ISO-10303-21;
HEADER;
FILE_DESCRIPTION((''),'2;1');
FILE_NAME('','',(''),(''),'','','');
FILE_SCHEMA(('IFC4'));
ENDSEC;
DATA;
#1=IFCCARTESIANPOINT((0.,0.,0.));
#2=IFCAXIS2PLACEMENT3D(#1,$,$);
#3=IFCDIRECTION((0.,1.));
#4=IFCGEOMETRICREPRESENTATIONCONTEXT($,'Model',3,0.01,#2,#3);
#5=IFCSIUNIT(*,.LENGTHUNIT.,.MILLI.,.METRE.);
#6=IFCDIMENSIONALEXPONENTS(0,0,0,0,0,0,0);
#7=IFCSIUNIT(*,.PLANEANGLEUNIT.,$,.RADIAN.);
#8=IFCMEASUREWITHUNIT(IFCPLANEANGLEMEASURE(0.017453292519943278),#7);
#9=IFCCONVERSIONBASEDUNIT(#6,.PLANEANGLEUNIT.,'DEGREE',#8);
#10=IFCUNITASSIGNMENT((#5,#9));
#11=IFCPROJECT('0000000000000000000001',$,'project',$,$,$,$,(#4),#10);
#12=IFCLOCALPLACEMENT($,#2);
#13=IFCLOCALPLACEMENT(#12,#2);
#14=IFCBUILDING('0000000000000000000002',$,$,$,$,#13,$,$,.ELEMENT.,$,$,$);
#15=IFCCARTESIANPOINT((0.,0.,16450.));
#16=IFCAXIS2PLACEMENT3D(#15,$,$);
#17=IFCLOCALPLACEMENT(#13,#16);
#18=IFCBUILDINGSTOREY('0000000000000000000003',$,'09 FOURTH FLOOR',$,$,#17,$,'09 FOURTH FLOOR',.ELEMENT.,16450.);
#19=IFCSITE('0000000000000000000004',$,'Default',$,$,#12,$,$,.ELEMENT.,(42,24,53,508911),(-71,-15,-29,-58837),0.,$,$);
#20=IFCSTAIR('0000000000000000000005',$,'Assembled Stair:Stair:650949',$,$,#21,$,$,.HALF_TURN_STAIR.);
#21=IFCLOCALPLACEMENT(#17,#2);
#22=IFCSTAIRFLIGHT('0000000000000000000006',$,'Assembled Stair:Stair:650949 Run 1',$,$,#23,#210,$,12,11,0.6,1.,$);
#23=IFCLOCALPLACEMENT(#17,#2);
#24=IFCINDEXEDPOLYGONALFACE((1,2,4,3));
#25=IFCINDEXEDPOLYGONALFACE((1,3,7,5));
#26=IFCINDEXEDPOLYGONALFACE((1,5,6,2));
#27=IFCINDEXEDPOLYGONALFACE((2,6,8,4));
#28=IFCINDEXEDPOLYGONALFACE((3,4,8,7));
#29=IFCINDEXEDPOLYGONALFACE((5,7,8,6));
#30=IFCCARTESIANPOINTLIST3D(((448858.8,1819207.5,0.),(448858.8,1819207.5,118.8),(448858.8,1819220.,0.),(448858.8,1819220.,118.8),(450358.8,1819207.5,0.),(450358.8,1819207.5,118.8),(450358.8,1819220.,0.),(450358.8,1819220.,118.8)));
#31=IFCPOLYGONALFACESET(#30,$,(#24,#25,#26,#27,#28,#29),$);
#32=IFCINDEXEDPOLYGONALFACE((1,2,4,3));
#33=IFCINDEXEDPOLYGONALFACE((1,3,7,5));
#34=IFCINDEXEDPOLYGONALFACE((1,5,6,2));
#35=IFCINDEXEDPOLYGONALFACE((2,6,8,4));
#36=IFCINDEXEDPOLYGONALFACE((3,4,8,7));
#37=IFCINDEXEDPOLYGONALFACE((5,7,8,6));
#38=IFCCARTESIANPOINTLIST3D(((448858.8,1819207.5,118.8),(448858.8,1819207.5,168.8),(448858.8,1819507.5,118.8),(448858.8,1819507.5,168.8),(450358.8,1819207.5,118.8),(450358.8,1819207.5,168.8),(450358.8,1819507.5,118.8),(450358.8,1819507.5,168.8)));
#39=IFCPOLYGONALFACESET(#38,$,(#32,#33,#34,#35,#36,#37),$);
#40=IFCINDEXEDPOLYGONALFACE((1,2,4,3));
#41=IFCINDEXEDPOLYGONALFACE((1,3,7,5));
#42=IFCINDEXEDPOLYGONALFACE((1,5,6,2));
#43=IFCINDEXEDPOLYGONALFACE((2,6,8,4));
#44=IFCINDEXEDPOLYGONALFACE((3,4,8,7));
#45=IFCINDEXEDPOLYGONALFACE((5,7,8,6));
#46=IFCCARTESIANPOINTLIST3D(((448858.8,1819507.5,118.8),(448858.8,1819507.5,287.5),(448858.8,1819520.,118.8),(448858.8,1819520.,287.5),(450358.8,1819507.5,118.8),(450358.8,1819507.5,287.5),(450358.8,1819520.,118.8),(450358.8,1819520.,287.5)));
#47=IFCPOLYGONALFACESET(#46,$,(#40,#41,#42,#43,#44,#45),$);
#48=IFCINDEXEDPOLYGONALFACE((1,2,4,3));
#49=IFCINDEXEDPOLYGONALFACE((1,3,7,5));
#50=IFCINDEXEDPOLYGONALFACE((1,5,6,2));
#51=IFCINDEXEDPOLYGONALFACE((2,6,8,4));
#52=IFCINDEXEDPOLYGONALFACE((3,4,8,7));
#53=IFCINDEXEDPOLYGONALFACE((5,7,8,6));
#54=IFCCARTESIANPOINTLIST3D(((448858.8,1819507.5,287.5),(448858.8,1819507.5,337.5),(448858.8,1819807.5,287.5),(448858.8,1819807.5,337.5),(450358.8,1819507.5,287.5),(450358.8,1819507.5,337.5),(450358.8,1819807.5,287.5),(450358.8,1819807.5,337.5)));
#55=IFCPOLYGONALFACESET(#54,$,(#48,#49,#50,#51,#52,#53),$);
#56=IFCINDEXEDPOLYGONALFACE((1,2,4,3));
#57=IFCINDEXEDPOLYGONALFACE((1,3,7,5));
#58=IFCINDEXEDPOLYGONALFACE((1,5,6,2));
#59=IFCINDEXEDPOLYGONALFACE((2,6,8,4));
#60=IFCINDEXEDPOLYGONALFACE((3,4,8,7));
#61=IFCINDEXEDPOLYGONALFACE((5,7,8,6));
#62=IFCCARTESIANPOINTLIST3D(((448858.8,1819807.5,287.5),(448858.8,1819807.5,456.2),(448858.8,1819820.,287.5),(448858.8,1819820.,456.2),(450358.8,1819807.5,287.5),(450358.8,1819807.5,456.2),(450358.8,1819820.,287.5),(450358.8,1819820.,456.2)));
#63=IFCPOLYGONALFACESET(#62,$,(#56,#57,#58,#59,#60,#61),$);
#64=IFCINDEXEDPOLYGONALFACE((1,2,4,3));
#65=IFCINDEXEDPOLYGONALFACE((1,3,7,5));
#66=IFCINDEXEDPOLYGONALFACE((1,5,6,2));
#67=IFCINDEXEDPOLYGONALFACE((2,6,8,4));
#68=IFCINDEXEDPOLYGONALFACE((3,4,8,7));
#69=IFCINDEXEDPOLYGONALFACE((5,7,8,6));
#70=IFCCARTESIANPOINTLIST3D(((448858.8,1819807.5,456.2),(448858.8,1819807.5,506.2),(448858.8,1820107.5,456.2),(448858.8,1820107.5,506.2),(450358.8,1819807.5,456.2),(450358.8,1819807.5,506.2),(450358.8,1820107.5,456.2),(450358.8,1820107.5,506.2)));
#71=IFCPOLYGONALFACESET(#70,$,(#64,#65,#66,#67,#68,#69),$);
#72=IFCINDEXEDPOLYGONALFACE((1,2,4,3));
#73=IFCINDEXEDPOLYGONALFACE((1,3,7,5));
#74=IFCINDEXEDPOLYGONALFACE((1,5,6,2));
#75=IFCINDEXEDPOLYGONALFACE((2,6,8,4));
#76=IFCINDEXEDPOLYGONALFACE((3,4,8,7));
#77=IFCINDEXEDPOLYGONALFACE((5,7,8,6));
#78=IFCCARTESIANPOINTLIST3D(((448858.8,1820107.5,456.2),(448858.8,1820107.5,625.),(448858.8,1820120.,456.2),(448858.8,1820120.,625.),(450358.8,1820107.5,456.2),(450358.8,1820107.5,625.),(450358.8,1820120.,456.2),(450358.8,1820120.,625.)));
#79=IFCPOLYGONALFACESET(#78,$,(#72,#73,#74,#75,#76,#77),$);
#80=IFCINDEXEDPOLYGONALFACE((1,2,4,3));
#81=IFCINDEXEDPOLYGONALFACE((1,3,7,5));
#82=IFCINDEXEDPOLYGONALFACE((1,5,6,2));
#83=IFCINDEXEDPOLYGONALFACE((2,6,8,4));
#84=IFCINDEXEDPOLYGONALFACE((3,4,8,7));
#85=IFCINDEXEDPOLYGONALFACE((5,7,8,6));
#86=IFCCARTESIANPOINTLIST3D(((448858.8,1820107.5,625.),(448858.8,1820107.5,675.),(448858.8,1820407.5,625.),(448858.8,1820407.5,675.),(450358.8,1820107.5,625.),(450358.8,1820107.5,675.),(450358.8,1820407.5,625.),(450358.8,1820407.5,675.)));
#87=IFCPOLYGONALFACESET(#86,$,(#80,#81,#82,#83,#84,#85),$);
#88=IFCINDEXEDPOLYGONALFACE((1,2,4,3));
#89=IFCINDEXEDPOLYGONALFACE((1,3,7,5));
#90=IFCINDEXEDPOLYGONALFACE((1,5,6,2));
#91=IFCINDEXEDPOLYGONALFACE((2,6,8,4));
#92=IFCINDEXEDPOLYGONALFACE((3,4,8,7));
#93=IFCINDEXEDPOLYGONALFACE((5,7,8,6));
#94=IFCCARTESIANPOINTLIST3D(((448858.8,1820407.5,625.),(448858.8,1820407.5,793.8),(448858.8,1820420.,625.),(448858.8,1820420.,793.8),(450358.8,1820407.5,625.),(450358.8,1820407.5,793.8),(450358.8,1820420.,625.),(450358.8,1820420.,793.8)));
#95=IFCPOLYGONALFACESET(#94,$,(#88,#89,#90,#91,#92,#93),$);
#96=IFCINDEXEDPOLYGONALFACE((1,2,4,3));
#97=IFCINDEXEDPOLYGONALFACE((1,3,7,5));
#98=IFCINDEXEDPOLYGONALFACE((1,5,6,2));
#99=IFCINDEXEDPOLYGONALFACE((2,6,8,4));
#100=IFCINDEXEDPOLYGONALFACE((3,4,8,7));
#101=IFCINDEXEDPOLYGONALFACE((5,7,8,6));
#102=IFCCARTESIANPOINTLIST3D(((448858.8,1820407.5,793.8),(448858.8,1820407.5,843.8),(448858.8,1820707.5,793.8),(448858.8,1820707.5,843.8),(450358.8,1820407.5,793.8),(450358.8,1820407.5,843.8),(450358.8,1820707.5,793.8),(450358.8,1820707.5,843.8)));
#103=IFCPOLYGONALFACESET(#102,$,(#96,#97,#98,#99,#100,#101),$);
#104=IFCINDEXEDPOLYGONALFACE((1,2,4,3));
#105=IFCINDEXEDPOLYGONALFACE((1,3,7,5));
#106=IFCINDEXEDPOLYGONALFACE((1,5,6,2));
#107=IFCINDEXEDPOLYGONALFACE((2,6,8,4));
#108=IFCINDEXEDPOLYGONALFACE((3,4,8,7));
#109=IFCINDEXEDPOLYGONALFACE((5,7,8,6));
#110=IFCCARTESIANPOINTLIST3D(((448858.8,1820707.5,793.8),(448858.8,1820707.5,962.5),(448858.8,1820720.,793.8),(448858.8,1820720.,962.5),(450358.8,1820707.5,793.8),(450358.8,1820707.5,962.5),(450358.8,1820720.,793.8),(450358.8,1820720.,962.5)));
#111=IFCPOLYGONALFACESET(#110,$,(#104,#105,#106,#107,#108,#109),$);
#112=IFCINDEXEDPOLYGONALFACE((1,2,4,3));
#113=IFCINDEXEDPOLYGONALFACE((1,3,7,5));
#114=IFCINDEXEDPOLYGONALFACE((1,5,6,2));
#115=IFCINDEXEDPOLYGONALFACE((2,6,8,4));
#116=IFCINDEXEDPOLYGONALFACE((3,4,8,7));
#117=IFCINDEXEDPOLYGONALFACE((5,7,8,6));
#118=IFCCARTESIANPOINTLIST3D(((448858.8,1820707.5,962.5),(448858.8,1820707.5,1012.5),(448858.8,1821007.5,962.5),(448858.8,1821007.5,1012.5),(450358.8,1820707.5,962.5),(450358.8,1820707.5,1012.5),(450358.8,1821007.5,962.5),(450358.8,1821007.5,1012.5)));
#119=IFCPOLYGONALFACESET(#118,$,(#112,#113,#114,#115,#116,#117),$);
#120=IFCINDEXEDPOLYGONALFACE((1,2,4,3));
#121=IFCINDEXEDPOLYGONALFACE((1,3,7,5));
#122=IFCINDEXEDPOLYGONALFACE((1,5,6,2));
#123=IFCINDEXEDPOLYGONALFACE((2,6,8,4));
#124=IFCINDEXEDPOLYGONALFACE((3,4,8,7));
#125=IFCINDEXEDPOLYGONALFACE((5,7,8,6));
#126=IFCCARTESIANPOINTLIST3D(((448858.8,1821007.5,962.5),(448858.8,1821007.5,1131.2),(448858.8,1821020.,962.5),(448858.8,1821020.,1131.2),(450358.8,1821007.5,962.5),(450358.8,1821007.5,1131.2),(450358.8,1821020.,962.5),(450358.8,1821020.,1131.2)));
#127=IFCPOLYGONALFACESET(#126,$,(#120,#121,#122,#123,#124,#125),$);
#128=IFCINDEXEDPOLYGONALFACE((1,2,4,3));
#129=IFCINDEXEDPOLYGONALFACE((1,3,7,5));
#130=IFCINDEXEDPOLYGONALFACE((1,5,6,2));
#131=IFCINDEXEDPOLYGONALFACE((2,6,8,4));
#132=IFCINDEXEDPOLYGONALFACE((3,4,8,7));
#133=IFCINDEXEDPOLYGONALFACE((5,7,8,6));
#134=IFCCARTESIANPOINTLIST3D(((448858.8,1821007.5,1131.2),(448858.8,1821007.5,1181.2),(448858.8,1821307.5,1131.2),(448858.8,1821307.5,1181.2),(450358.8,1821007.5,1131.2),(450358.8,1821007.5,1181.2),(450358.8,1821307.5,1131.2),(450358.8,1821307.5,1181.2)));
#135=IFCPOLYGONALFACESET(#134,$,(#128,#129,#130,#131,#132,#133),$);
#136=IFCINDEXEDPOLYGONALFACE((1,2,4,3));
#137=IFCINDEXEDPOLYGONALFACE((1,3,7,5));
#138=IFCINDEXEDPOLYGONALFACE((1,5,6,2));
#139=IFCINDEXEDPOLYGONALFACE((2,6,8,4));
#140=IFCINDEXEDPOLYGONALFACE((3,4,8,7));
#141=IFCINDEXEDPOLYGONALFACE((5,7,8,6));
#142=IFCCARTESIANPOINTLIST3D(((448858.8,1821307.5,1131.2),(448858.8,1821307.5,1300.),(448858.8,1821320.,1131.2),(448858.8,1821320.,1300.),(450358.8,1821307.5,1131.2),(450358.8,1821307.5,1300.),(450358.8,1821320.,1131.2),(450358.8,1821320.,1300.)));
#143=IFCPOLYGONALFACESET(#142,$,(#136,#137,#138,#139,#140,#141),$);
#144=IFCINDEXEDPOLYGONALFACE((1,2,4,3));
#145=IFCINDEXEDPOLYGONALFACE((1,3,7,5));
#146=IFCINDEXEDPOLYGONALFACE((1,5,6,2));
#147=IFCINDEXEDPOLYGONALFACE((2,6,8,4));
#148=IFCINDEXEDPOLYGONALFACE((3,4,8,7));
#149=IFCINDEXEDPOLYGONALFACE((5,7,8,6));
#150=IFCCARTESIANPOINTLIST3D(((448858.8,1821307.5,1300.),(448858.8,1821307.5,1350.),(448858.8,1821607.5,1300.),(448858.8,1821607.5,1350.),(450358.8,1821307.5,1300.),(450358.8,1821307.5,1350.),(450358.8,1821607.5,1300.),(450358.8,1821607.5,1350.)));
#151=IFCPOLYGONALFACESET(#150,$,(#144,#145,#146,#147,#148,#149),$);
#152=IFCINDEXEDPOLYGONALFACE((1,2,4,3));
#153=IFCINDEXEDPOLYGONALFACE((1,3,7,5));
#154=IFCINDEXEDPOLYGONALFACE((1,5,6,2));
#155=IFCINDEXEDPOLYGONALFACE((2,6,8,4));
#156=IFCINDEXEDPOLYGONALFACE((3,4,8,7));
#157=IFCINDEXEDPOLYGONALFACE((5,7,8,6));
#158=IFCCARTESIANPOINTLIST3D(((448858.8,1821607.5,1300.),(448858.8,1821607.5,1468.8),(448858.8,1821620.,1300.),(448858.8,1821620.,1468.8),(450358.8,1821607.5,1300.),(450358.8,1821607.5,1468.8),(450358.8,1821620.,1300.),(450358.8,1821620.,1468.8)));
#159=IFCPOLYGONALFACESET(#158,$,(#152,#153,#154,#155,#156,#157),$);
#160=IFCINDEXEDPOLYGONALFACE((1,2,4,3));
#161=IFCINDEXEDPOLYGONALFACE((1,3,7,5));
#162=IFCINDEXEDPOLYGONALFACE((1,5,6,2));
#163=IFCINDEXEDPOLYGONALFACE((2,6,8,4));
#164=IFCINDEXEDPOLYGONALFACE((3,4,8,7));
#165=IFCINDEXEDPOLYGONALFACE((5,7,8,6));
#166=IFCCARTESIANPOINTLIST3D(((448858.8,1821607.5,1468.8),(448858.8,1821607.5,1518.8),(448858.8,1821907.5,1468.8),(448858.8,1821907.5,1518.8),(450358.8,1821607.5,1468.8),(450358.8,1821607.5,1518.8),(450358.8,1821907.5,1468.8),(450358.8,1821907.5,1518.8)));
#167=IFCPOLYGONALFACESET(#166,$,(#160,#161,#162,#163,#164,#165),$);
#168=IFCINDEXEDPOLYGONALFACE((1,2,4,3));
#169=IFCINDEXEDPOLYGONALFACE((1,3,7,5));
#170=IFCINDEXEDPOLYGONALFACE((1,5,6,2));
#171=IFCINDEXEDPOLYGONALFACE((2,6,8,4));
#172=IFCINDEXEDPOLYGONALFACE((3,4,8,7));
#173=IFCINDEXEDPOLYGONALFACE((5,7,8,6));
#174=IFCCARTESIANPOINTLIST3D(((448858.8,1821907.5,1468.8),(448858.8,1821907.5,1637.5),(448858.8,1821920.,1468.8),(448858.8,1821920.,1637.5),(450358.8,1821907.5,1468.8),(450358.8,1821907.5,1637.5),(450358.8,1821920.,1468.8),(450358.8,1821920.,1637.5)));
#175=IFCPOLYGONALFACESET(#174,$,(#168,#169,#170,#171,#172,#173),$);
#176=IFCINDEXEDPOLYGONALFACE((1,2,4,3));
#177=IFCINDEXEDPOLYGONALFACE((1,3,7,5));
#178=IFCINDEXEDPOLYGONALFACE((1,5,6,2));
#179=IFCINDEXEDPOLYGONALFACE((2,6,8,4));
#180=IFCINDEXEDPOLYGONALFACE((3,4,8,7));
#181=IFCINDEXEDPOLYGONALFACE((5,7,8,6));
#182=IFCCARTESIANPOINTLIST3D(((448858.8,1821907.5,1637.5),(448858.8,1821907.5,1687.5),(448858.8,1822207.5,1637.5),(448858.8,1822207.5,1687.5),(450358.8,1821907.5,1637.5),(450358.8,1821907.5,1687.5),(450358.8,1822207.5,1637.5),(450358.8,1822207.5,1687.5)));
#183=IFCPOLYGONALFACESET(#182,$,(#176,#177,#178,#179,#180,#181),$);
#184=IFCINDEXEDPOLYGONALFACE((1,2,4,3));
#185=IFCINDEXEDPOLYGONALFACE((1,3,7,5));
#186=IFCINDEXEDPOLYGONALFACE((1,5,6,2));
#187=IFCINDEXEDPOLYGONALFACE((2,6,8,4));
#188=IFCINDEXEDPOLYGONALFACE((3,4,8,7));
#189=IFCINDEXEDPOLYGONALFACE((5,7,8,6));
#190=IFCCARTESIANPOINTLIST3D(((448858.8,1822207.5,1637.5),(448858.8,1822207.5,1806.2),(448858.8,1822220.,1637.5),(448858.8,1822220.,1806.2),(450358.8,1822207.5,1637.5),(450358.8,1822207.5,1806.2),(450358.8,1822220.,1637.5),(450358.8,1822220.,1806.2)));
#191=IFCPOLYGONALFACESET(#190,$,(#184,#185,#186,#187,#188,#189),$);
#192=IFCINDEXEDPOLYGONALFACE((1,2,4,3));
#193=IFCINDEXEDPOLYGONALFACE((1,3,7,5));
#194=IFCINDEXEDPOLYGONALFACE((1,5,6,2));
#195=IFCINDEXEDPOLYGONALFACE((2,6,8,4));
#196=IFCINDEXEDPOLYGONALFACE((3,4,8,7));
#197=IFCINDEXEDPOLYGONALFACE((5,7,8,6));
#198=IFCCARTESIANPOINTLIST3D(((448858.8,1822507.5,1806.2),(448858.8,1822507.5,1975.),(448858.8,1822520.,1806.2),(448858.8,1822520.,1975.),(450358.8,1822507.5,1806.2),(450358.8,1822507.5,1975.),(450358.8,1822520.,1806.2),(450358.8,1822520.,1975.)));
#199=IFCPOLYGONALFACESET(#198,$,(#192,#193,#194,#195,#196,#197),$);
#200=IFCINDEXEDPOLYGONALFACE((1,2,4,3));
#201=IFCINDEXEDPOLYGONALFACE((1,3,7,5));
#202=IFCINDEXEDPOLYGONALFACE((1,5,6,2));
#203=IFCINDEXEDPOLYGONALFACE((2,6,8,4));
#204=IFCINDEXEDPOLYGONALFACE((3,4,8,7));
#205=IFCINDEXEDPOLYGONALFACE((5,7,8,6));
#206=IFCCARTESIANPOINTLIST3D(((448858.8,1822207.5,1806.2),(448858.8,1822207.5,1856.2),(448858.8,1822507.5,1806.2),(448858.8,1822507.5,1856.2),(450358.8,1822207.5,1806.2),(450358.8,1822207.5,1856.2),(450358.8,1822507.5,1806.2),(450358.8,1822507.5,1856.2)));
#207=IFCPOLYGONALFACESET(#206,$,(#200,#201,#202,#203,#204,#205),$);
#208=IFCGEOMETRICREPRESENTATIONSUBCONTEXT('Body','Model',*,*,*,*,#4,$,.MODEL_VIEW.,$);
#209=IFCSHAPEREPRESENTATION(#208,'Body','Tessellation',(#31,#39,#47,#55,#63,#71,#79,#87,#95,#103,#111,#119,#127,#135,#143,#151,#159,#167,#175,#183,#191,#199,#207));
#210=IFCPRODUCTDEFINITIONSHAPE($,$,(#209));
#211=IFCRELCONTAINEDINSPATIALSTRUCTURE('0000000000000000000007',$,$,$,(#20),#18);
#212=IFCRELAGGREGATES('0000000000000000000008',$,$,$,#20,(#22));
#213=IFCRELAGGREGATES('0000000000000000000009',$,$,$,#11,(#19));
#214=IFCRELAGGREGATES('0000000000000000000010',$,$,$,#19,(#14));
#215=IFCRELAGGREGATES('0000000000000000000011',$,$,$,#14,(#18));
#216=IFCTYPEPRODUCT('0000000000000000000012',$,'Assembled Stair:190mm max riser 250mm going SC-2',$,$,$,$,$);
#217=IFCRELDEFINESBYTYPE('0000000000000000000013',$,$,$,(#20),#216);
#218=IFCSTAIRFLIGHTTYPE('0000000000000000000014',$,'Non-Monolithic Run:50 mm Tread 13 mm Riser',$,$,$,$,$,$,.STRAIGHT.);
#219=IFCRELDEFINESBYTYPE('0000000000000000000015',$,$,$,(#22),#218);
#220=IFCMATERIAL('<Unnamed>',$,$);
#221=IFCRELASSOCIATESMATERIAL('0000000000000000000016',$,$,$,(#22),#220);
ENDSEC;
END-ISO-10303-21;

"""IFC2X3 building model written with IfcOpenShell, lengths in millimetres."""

from ifc_helpers import new_model, entity, si_unit, converted_unit, direction, frame, frame_2d, origin, origin_2d_with_axis, place, context, subcontext, project, spatial, rectangle, extrude, material, type_object, element, aggregate, save


model = new_model("IFC2X3")

# Units and contexts
model_context = context("Model", 3, precision=0.01, world=origin(), true_north=direction((0.0, 1.0)))
body_context = subcontext(model_context, "Body", "Model", "MODEL_VIEW")
ifc_project = project(units=[si_unit("LENGTHUNIT", "METRE", prefix="MILLI"), converted_unit("PLANEANGLEUNIT", "DEGREE", entity("IfcPlaneAngleMeasure", 0.017453292519943278), si_unit("PLANEANGLEUNIT", "RADIAN"), dimensions=[0, 0, 0, 0, 0, 0, 0])], contexts=[model_context])

# Site, building, storey
site_placement = place(None, origin())
site = spatial("IfcSite", under=ifc_project, at=site_placement, Name="Default", CompositionType="ELEMENT", RefLatitude=(42, 24, 53, 508911), RefLongitude=(-71, -15, -29, -58837), RefElevation=0.0)
building_placement = place(site_placement, origin())
building = spatial("IfcBuilding", under=site, at=building_placement, CompositionType="ELEMENT")
storey_placement = place(building_placement, frame((0.0, 0.0, 16450.0)))
storey = spatial("IfcBuildingStorey", under=building, at=storey_placement, Name="09 FOURTH FLOOR", LongName="09 FOURTH FLOOR", CompositionType="ELEMENT", Elevation=16450.0)

# Stair
ifc_material_1 = material(Name="<Unnamed>")
type_product_1 = type_object("IfcTypeProduct", Name="Assembled Stair:190mm max riser 250mm going SC-2")
stair_1_placement = place(storey_placement, origin())
stair_1 = element("IfcStair", 1, at=stair_1_placement, inside=storey, type_object=type_product_1, Name="Assembled Stair:Stair:650949", ShapeType="HALF_TURN_STAIR")

# Stair flight
stair_flight_type = type_object("IfcStairFlightType", Name="Non-Monolithic Run:50 mm Tread 13 mm Riser", PredefinedType="STRAIGHT")
stair_flight_1_placement = place(stair_1_placement, origin())
stair_flight_1 = element("IfcStairFlight", 2, at=stair_flight_1_placement, type_object=stair_flight_type, material=ifc_material_1, Name="Assembled Stair:Stair:650949 Run 1", NumberOfRiser=12, NumberOfTreads=11, RiserHeight=0.6, TreadLength=1.0, context=body_context, shape_type="SweptSolid", body=[
    extrude(rectangle(XDim=1500.0, YDim=12.5, at=origin_2d_with_axis()), frame((449608.8, 1819213.8, 0.0), z_axis=(0.0, 0.0, 1.0), x_axis=(-1.0, 0.0, 0.0)), (0.0, 0.0, 1.0), 118.8),
    extrude(rectangle(XDim=300.0, YDim=1500.0, at=frame_2d((0.0, 0.0), x_axis=(1.0, 0.0))), frame((449608.8, 1819357.5, 118.8), z_axis=(0.0, 0.0, 1.0), x_axis=(0.0, -1.0, 0.0)), (0.0, 0.0, 1.0), 50.0),
    extrude(rectangle(XDim=1500.0, YDim=12.5, at=origin_2d_with_axis()), frame((449608.8, 1819513.8, 118.8), z_axis=(0.0, 0.0, 1.0), x_axis=(-1.0, 0.0, 0.0)), (0.0, 0.0, 1.0), 168.8),
    extrude(rectangle(XDim=300.0, YDim=1500.0, at=origin_2d_with_axis()), frame((449608.8, 1819657.5, 287.5), z_axis=(0.0, 0.0, 1.0), x_axis=(0.0, -1.0, 0.0)), (0.0, 0.0, 1.0), 50.0),
    extrude(rectangle(XDim=1500.0, YDim=12.5, at=origin_2d_with_axis()), frame((449608.8, 1819813.8, 287.5), z_axis=(0.0, 0.0, 1.0), x_axis=(-1.0, 0.0, 0.0)), (0.0, 0.0, 1.0), 168.8),
    extrude(rectangle(XDim=300.0, YDim=1500.0, at=origin_2d_with_axis()), frame((449608.8, 1819957.5, 456.3), z_axis=(0.0, 0.0, 1.0), x_axis=(0.0, -1.0, 0.0)), (0.0, 0.0, 1.0), 50.0),
    extrude(rectangle(XDim=1500.0, YDim=12.5, at=origin_2d_with_axis()), frame((449608.8, 1820113.8, 456.3), z_axis=(0.0, 0.0, 1.0), x_axis=(-1.0, 0.0, 0.0)), (0.0, 0.0, 1.0), 168.8),
    extrude(rectangle(XDim=300.0, YDim=1500.0, at=origin_2d_with_axis()), frame((449608.8, 1820257.5, 625.0), z_axis=(0.0, 0.0, 1.0), x_axis=(0.0, -1.0, 0.0)), (0.0, 0.0, 1.0), 50.0),
    extrude(rectangle(XDim=1500.0, YDim=12.5, at=origin_2d_with_axis()), frame((449608.8, 1820413.8, 625.0), z_axis=(0.0, 0.0, 1.0), x_axis=(-1.0, 0.0, 0.0)), (0.0, 0.0, 1.0), 168.8),
    extrude(rectangle(XDim=300.0, YDim=1500.0, at=origin_2d_with_axis()), frame((449608.8, 1820557.5, 793.8), z_axis=(0.0, 0.0, 1.0), x_axis=(0.0, -1.0, 0.0)), (0.0, 0.0, 1.0), 50.0),
    extrude(rectangle(XDim=1500.0, YDim=12.5, at=origin_2d_with_axis()), frame((449608.8, 1820713.8, 793.8), z_axis=(0.0, 0.0, 1.0), x_axis=(-1.0, 0.0, 0.0)), (0.0, 0.0, 1.0), 168.8),
    extrude(rectangle(XDim=300.0, YDim=1500.0, at=origin_2d_with_axis()), frame((449608.8, 1820857.5, 962.5), z_axis=(0.0, 0.0, 1.0), x_axis=(0.0, -1.0, 0.0)), (0.0, 0.0, 1.0), 50.0),
    extrude(rectangle(XDim=1500.0, YDim=12.5, at=origin_2d_with_axis()), frame((449608.8, 1821013.8, 962.5), z_axis=(0.0, 0.0, 1.0), x_axis=(-1.0, 0.0, 0.0)), (0.0, 0.0, 1.0), 168.8),
    extrude(rectangle(XDim=300.0, YDim=1500.0, at=origin_2d_with_axis()), frame((449608.8, 1821157.5, 1131.3), z_axis=(0.0, 0.0, 1.0), x_axis=(0.0, -1.0, 0.0)), (0.0, 0.0, 1.0), 50.0),
    extrude(rectangle(XDim=1500.0, YDim=12.5, at=origin_2d_with_axis()), frame((449608.8, 1821313.8, 1131.3), z_axis=(0.0, 0.0, 1.0), x_axis=(-1.0, 0.0, 0.0)), (0.0, 0.0, 1.0), 168.8),
    extrude(rectangle(XDim=300.0, YDim=1500.0, at=origin_2d_with_axis()), frame((449608.8, 1821457.5, 1300.0), z_axis=(0.0, 0.0, 1.0), x_axis=(0.0, -1.0, 0.0)), (0.0, 0.0, 1.0), 50.0),
    extrude(rectangle(XDim=1500.0, YDim=12.5, at=origin_2d_with_axis()), frame((449608.8, 1821613.8, 1300.0), z_axis=(0.0, 0.0, 1.0), x_axis=(-1.0, 0.0, 0.0)), (0.0, 0.0, 1.0), 168.8),
    extrude(rectangle(XDim=300.0, YDim=1500.0, at=origin_2d_with_axis()), frame((449608.8, 1821757.5, 1468.8), z_axis=(0.0, 0.0, 1.0), x_axis=(0.0, -1.0, 0.0)), (0.0, 0.0, 1.0), 50.0),
    extrude(rectangle(XDim=1500.0, YDim=12.5, at=origin_2d_with_axis()), frame((449608.8, 1821913.8, 1468.8), z_axis=(0.0, 0.0, 1.0), x_axis=(-1.0, 0.0, 0.0)), (0.0, 0.0, 1.0), 168.8),
    extrude(rectangle(XDim=300.0, YDim=1500.0, at=origin_2d_with_axis()), frame((449608.8, 1822057.5, 1637.5), z_axis=(0.0, 0.0, 1.0), x_axis=(0.0, -1.0, 0.0)), (0.0, 0.0, 1.0), 50.0),
    extrude(rectangle(XDim=1500.0, YDim=12.5, at=origin_2d_with_axis()), frame((449608.8, 1822213.8, 1637.5), z_axis=(0.0, 0.0, 1.0), x_axis=(-1.0, 0.0, 0.0)), (0.0, 0.0, 1.0), 168.8),
    extrude(rectangle(XDim=1500.0, YDim=12.5, at=origin_2d_with_axis()), frame((449608.8, 1822513.8, 1806.3), z_axis=(0.0, 0.0, 1.0), x_axis=(-1.0, 0.0, 0.0)), (0.0, 0.0, 1.0), 168.8),
    extrude(rectangle(XDim=300.0, YDim=1500.0, at=origin_2d_with_axis()), frame((449608.8, 1822357.5, 1806.3), z_axis=(0.0, 0.0, 1.0), x_axis=(0.0, -1.0, 0.0)), (0.0, 0.0, 1.0), 50.0),
])

aggregate(stair_1, [stair_flight_1])

save(model, "model.ifc")
